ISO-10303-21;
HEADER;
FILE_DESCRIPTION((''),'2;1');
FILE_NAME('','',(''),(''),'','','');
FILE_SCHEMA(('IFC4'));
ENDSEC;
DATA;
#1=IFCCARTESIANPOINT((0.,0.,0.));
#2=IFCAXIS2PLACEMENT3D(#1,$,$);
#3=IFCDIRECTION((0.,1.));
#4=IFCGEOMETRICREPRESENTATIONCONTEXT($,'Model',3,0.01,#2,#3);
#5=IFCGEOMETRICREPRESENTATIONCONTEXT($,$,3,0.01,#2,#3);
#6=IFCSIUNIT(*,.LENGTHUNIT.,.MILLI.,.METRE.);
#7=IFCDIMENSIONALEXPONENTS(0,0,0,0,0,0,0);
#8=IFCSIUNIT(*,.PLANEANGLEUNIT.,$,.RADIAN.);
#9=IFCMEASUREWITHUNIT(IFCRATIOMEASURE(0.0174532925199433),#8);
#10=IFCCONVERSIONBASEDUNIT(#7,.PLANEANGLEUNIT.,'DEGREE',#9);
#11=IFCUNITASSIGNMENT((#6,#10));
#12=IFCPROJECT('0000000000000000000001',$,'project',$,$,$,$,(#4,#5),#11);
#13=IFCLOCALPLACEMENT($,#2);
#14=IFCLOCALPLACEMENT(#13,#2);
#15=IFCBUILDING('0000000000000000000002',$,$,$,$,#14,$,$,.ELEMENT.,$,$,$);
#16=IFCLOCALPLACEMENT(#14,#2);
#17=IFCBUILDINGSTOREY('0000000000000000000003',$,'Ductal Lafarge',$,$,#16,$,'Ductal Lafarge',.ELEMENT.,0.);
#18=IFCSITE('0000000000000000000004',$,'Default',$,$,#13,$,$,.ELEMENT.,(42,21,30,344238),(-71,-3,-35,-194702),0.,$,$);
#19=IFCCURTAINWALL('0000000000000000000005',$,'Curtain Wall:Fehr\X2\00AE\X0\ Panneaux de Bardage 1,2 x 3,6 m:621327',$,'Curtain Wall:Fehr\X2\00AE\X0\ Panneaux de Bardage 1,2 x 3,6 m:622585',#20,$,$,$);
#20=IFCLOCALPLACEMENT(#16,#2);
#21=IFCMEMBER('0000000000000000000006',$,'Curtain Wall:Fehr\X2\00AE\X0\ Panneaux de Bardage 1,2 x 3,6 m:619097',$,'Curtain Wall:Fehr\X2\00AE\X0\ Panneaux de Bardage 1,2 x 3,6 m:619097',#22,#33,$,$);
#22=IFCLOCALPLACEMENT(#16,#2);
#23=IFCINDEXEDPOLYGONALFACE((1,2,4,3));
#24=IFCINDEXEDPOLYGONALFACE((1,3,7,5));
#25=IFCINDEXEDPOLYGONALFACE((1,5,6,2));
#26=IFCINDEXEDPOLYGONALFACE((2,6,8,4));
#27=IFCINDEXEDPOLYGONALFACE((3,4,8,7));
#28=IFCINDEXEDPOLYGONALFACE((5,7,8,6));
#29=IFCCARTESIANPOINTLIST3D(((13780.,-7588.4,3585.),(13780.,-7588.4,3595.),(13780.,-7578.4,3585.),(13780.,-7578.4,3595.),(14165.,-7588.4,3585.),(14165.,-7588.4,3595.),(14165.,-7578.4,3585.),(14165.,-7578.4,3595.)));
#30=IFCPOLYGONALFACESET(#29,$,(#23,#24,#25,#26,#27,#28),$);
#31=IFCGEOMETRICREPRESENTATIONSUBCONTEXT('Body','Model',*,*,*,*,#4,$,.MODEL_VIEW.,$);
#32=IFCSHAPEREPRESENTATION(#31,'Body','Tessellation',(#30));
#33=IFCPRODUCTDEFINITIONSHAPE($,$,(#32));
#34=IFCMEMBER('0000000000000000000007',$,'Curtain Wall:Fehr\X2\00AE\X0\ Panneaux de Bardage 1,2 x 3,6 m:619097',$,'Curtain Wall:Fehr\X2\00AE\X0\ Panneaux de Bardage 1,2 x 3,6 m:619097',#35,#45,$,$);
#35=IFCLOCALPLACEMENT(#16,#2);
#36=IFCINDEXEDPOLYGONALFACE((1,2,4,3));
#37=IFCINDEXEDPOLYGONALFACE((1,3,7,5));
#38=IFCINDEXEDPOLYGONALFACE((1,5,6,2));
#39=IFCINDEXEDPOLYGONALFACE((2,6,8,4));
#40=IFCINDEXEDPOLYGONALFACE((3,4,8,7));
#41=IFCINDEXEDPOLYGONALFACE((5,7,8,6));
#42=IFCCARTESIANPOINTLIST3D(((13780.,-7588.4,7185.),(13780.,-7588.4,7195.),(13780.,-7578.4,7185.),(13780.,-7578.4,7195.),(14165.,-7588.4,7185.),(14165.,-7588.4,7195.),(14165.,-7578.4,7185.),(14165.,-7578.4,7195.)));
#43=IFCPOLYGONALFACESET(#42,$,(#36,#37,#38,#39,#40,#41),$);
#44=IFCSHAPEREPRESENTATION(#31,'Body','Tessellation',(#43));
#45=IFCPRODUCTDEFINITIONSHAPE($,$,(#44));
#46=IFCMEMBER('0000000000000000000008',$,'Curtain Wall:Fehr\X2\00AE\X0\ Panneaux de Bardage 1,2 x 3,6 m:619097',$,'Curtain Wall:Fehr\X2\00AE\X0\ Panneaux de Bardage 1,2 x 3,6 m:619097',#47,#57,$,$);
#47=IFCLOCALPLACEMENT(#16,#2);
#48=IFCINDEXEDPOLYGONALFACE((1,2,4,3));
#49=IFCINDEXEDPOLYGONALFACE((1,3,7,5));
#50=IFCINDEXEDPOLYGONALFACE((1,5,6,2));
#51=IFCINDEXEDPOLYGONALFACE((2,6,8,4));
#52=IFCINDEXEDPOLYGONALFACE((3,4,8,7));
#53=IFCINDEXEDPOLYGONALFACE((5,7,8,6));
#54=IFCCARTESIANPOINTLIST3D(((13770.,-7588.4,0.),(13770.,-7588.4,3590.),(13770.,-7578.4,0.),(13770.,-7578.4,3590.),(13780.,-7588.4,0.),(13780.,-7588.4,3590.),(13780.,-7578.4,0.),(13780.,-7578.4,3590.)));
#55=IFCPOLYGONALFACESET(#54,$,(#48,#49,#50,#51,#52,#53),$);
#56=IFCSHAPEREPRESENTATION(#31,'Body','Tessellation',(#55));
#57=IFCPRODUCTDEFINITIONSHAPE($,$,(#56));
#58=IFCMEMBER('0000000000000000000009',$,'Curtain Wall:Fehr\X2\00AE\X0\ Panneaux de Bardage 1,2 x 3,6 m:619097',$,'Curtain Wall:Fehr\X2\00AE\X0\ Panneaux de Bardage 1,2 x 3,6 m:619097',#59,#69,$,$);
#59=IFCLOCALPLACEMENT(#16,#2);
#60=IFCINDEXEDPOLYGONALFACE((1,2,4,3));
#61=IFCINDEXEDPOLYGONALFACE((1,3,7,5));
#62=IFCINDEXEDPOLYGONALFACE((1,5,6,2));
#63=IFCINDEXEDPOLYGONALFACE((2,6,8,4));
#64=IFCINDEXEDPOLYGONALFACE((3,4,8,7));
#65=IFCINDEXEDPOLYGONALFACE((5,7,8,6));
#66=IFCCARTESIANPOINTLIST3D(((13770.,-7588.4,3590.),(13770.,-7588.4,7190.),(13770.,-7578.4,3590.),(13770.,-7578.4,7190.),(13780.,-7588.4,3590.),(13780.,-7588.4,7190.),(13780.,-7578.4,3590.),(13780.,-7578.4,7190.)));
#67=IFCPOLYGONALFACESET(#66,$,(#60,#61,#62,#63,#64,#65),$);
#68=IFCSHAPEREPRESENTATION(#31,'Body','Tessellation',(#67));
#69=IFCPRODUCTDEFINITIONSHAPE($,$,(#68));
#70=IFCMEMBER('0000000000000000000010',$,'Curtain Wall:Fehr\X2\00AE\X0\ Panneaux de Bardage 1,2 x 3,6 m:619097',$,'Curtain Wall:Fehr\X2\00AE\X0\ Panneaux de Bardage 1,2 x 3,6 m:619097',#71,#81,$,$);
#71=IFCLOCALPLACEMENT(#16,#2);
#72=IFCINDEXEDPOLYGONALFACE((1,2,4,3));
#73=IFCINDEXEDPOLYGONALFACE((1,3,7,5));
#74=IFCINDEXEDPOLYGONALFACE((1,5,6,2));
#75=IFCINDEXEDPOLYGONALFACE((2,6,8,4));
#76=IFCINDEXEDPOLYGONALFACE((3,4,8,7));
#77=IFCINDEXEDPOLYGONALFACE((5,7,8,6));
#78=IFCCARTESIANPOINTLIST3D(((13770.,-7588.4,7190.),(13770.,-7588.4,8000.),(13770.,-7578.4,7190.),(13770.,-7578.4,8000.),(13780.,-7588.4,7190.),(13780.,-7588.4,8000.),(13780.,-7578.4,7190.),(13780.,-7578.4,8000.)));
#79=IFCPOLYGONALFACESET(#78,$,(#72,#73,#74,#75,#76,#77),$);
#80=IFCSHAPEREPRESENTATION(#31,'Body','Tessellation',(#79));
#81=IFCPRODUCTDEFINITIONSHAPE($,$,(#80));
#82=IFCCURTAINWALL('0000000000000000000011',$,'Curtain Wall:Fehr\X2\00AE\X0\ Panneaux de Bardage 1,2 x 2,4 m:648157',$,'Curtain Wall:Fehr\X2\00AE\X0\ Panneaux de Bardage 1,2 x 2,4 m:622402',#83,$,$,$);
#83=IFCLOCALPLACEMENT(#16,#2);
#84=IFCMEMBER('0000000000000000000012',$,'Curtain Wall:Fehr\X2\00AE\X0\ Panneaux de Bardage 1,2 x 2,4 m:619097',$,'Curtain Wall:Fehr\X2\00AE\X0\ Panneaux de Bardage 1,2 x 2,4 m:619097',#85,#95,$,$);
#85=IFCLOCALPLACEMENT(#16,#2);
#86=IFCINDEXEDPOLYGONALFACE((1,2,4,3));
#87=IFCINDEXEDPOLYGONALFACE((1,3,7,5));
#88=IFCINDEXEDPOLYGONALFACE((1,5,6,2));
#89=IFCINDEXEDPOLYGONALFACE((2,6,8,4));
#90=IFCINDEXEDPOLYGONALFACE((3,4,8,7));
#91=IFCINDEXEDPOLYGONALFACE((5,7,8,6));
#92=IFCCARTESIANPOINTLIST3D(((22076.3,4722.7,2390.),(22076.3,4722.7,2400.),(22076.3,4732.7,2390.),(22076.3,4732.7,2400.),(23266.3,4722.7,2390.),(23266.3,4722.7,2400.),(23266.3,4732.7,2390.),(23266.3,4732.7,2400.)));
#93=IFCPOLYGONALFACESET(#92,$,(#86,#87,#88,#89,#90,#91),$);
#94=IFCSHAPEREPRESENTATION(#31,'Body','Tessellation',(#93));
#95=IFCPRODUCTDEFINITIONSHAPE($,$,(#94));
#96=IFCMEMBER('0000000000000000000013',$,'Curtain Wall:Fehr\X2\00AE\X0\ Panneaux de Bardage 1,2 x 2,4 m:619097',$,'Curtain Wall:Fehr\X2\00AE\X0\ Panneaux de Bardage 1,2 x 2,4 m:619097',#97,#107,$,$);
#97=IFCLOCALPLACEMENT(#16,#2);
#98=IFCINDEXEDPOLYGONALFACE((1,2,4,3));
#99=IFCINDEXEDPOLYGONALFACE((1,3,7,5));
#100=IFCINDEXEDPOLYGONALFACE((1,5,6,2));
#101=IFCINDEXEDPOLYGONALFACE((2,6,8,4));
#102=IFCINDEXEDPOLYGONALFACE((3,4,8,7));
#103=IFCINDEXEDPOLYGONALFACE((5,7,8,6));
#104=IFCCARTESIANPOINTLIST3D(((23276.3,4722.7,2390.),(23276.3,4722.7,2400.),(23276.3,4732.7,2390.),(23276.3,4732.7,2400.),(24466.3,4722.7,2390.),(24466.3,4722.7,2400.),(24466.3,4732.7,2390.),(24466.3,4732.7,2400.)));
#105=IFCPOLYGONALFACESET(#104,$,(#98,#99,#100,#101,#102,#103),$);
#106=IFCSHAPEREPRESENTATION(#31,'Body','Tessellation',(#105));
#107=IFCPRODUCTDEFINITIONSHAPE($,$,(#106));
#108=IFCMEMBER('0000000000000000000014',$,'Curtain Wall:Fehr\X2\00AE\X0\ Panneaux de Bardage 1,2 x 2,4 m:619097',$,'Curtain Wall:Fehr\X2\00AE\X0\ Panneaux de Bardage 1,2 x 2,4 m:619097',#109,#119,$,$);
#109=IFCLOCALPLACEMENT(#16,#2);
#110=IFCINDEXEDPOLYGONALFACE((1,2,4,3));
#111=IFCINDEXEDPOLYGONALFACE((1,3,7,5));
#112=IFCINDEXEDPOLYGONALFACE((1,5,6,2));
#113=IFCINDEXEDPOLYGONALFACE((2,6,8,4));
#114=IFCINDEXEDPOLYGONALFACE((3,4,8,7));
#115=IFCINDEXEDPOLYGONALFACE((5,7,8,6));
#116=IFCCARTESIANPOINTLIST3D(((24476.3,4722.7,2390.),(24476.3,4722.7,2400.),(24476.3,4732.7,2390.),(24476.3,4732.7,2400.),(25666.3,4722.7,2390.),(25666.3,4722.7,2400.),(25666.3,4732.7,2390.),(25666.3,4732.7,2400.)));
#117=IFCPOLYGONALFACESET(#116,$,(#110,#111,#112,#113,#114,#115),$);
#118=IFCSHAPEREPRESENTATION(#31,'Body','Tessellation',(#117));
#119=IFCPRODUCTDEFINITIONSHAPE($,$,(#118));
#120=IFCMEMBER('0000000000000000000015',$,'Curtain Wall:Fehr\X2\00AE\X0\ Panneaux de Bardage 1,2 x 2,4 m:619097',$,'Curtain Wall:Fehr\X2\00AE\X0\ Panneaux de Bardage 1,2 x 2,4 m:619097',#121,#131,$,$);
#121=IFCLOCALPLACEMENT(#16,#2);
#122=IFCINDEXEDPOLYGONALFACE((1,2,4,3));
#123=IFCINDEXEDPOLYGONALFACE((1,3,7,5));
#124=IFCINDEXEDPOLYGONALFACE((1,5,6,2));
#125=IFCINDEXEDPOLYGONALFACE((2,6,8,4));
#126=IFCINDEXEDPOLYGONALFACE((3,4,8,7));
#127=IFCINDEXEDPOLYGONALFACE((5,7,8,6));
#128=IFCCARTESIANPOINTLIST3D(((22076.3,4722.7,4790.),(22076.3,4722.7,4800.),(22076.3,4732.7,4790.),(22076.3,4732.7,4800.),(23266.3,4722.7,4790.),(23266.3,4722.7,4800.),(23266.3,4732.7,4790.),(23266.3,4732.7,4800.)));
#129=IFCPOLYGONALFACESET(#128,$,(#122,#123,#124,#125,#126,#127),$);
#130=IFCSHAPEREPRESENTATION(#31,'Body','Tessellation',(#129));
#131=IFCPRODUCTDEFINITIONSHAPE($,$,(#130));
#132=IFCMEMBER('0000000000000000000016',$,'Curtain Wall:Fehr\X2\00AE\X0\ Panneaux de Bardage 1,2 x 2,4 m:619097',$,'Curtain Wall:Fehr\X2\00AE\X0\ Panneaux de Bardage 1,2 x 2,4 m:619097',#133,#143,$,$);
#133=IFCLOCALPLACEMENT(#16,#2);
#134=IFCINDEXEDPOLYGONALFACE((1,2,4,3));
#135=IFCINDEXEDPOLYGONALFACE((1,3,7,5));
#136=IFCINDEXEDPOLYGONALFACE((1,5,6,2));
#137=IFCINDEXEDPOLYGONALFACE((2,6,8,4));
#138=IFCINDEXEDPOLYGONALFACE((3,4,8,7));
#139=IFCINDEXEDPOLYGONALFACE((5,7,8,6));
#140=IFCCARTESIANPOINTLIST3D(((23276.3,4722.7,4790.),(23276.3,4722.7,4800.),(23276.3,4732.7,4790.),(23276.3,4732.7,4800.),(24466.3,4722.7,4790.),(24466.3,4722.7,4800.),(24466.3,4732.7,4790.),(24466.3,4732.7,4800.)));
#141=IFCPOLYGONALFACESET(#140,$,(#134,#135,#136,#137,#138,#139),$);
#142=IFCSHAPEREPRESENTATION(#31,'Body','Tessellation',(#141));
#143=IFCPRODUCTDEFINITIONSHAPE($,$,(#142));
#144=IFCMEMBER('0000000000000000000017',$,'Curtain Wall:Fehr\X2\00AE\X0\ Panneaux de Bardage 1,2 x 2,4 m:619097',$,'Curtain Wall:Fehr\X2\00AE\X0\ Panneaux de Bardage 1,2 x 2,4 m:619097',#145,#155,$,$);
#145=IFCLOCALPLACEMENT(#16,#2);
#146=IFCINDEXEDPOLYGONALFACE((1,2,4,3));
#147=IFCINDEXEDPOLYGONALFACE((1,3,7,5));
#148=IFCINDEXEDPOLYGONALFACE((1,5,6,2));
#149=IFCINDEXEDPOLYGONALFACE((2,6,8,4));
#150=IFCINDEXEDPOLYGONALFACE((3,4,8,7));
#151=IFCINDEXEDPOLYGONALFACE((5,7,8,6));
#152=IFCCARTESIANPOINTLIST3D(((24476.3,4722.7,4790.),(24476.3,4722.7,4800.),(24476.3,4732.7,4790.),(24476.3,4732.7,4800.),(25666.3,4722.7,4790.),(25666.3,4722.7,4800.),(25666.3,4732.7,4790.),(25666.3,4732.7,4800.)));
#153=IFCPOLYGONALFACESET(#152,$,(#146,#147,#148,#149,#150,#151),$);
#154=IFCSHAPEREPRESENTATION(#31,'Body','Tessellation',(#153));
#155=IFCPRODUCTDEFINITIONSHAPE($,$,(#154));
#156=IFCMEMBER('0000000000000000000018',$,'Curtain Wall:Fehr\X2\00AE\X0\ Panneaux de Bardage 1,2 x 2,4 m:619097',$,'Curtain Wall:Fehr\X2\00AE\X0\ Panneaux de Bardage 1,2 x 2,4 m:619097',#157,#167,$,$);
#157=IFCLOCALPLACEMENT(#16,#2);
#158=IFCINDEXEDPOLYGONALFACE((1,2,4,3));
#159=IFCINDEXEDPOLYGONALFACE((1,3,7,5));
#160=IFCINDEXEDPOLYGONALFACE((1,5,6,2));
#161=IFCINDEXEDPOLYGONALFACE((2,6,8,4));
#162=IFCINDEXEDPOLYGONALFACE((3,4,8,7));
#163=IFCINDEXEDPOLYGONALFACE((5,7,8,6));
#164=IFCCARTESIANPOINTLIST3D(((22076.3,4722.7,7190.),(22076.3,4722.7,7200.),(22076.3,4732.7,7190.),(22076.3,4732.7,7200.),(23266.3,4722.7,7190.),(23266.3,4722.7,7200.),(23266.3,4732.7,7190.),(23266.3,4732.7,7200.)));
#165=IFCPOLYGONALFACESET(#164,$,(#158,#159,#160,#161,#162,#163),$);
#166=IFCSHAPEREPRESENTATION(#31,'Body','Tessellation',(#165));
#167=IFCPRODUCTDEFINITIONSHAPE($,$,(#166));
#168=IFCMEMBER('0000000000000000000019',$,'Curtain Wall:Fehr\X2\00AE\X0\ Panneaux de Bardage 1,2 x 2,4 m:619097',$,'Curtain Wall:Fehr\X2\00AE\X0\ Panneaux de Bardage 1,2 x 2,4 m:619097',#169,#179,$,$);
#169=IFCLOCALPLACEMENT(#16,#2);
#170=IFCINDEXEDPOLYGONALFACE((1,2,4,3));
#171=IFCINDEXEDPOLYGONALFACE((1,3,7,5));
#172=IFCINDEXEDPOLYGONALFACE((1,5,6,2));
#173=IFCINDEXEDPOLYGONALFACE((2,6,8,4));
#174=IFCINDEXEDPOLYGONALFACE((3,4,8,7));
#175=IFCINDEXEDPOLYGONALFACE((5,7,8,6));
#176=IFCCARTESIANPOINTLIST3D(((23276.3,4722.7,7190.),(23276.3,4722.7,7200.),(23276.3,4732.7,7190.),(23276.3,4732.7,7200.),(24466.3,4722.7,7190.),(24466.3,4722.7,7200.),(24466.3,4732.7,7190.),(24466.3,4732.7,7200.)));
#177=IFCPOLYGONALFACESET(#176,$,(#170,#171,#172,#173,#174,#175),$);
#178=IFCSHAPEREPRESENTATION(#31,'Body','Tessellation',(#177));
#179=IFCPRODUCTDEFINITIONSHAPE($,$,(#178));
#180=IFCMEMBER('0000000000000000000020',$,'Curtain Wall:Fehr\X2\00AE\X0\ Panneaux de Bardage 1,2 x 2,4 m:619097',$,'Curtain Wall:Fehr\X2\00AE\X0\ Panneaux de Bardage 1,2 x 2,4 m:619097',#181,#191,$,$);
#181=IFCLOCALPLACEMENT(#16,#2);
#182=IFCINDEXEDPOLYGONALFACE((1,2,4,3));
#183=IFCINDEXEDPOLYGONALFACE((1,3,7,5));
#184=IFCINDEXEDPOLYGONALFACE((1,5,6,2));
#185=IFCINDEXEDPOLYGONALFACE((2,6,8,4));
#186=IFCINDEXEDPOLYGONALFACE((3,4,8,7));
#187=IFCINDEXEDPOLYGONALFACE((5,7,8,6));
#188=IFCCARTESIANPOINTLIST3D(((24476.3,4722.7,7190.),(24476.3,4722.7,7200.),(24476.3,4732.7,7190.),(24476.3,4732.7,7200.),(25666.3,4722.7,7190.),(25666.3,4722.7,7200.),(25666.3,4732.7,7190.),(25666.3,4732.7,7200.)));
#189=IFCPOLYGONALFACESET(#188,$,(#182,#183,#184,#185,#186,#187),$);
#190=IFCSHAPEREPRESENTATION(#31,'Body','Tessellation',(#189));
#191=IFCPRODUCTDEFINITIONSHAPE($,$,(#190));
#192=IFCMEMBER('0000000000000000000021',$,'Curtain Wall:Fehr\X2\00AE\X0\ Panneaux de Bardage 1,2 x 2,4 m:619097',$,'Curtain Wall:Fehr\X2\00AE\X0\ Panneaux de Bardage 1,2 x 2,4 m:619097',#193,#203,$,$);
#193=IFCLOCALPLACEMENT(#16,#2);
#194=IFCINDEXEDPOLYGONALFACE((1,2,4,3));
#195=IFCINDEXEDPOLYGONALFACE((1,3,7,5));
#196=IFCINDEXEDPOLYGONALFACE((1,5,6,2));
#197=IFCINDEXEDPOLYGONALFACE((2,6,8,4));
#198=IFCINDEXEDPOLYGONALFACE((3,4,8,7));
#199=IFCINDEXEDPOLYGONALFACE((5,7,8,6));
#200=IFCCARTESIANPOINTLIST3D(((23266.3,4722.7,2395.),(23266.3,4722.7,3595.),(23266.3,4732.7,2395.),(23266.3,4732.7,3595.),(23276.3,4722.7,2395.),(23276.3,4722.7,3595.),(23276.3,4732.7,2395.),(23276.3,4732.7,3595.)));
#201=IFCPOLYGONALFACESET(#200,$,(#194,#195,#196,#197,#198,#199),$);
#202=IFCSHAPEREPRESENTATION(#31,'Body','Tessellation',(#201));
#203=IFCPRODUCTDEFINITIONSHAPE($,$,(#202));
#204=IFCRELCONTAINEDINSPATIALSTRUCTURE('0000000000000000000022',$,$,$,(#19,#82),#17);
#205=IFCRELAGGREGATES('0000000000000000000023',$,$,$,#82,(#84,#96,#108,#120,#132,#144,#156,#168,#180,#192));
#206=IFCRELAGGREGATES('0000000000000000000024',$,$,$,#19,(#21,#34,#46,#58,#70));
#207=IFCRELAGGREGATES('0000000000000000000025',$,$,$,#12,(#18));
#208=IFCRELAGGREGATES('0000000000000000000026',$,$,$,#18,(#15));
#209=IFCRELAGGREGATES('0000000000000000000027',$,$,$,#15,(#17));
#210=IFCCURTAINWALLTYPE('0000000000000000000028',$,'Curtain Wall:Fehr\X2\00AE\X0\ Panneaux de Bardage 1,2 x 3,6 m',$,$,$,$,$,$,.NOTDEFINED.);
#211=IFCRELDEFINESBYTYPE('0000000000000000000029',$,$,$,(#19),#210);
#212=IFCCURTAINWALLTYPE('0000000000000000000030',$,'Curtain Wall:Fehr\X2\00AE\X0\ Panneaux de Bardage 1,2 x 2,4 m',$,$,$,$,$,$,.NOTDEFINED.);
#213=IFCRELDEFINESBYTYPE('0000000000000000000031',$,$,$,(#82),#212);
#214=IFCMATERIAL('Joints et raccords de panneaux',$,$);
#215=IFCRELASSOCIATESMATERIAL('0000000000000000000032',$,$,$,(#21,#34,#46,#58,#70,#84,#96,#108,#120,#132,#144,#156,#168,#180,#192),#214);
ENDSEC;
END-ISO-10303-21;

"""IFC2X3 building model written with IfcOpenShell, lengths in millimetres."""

from ifc_helpers import new_model, entity, si_unit, converted_unit, direction, frame, frame_2d, origin, place, context, subcontext, project, spatial, rectangle, extrude, material, type_object, element, aggregate, save


model = new_model("IFC2X3")

# Units and contexts
model_context = context("Model", 3, precision=0.01, world=origin(), true_north=direction((0.0, 1.0)))
context_of_model = context(None, 3, precision=0.01, world=origin(), true_north=direction((0.0, 1.0)))
body_context = subcontext(model_context, "Body", "Model", "MODEL_VIEW")
ifc_project = project(units=[si_unit("LENGTHUNIT", "METRE", prefix="MILLI"), converted_unit("PLANEANGLEUNIT", "DEGREE", entity("IfcRatioMeasure", 0.0174532925199433), si_unit("PLANEANGLEUNIT", "RADIAN"), dimensions=[0, 0, 0, 0, 0, 0, 0])], contexts=[model_context, context_of_model])

# Site, building, storey
site_placement = place(None, origin())
site = spatial("IfcSite", under=ifc_project, at=site_placement, Name="Default", CompositionType="ELEMENT", RefLatitude=(42, 21, 30, 344238), RefLongitude=(-71, -3, -35, -194702), RefElevation=0.0)
building_placement = place(site_placement, origin())
building = spatial("IfcBuilding", under=site, at=building_placement, CompositionType="ELEMENT")
storey_placement = place(building_placement, origin())
storey = spatial("IfcBuildingStorey", under=building, at=storey_placement, Name="Ductal Lafarge", LongName="Ductal Lafarge", CompositionType="ELEMENT", Elevation=0.0)

# Curtain walls, members
curtain_wall_type_1 = type_object("IfcCurtainWallType", Name="Curtain Wall:Fehr® Panneaux de Bardage 1,2 x 3,6 m", PredefinedType="NOTDEFINED")
curtain_wall_1_placement = place(storey_placement, origin())
curtain_wall_1 = element("IfcCurtainWall", 1, at=curtain_wall_1_placement, inside=storey, type_object=curtain_wall_type_1, Name="Curtain Wall:Fehr® Panneaux de Bardage 1,2 x 3,6 m:621327", ObjectType="Curtain Wall:Fehr® Panneaux de Bardage 1,2 x 3,6 m:622585")
ifc_material_1 = material(Name="Joints et raccords de panneaux")
member_1_placement = place(curtain_wall_1_placement, frame((13780.0, -7588.4, 3585.0)))
member_1 = element("IfcMember", 2, at=member_1_placement, material=ifc_material_1, Name="Curtain Wall:Fehr® Panneaux de Bardage 1,2 x 3,6 m:619097", ObjectType="Curtain Wall:Fehr® Panneaux de Bardage 1,2 x 3,6 m:619097", context=body_context, shape_type="SweptSolid", body=[
    extrude(rectangle(XDim=385.0, YDim=10.0, at=frame_2d((0.0, 0.0), x_axis=(1.0, 0.0))), frame((192.5, 5.0, 0.0), z_axis=(0.0, 0.0, 1.0), x_axis=(-1.0, 0.0, 0.0)), (0.0, 0.0, 1.0), 10.0),
])
member_2_placement = place(curtain_wall_1_placement, frame((13780.0, -7588.4, 7185.0)))
member_2 = element("IfcMember", 3, at=member_2_placement, material=ifc_material_1, Name="Curtain Wall:Fehr® Panneaux de Bardage 1,2 x 3,6 m:619097", ObjectType="Curtain Wall:Fehr® Panneaux de Bardage 1,2 x 3,6 m:619097", context=body_context, shape_type="SweptSolid", body=[
    extrude(rectangle(XDim=385.0, YDim=10.0, at=frame_2d((0.0, 0.0), x_axis=(1.0, 0.0))), frame((192.5, 5.0, 0.0), z_axis=(0.0, 0.0, 1.0), x_axis=(-1.0, 0.0, 0.0)), (0.0, 0.0, 1.0), 10.0),
])
member_3_placement = place(curtain_wall_1_placement, frame((13770.0, -7588.4, 0.0)))
member_3 = element("IfcMember", 4, at=member_3_placement, material=ifc_material_1, Name="Curtain Wall:Fehr® Panneaux de Bardage 1,2 x 3,6 m:619097", ObjectType="Curtain Wall:Fehr® Panneaux de Bardage 1,2 x 3,6 m:619097", context=body_context, shape_type="SweptSolid", body=[
    extrude(rectangle(XDim=10.0, YDim=10.0, at=frame_2d((0.0, 0.0), x_axis=(1.0, 0.0))), frame((5.0, 5.0, 0.0), z_axis=(0.0, 0.0, 1.0), x_axis=(0.0, 1.0, 0.0)), (0.0, 0.0, 1.0), 3590.0),
])
member_4_placement = place(curtain_wall_1_placement, frame((13770.0, -7588.4, 3590.0)))
member_4 = element("IfcMember", 5, at=member_4_placement, material=ifc_material_1, Name="Curtain Wall:Fehr® Panneaux de Bardage 1,2 x 3,6 m:619097", ObjectType="Curtain Wall:Fehr® Panneaux de Bardage 1,2 x 3,6 m:619097", context=body_context, shape_type="SweptSolid", body=[
    extrude(rectangle(XDim=10.0, YDim=10.0, at=frame_2d((0.0, 0.0), x_axis=(1.0, 0.0))), frame((5.0, 5.0, 0.0), z_axis=(0.0, 0.0, 1.0), x_axis=(0.0, 1.0, 0.0)), (0.0, 0.0, 1.0), 3600.0),
])
member_5_placement = place(curtain_wall_1_placement, frame((13770.0, -7588.4, 7190.0)))
member_5 = element("IfcMember", 6, at=member_5_placement, material=ifc_material_1, Name="Curtain Wall:Fehr® Panneaux de Bardage 1,2 x 3,6 m:619097", ObjectType="Curtain Wall:Fehr® Panneaux de Bardage 1,2 x 3,6 m:619097", context=body_context, shape_type="SweptSolid", body=[
    extrude(rectangle(XDim=10.0, YDim=10.0, at=frame_2d((0.0, 0.0), x_axis=(1.0, 0.0))), frame((5.0, 5.0, 0.0), z_axis=(0.0, 0.0, 1.0), x_axis=(0.0, 1.0, 0.0)), (0.0, 0.0, 1.0), 810.0),
])
curtain_wall_type_2 = type_object("IfcCurtainWallType", Name="Curtain Wall:Fehr® Panneaux de Bardage 1,2 x 2,4 m", PredefinedType="NOTDEFINED")
curtain_wall_2_placement = place(storey_placement, origin())
curtain_wall_2 = element("IfcCurtainWall", 7, at=curtain_wall_2_placement, inside=storey, type_object=curtain_wall_type_2, Name="Curtain Wall:Fehr® Panneaux de Bardage 1,2 x 2,4 m:648157", ObjectType="Curtain Wall:Fehr® Panneaux de Bardage 1,2 x 2,4 m:622402")
member_6_placement = place(curtain_wall_2_placement, frame((22076.3, 4722.7, 2390.0)))
member_6 = element("IfcMember", 8, at=member_6_placement, material=ifc_material_1, Name="Curtain Wall:Fehr® Panneaux de Bardage 1,2 x 2,4 m:619097", ObjectType="Curtain Wall:Fehr® Panneaux de Bardage 1,2 x 2,4 m:619097", context=body_context, shape_type="SweptSolid", body=[
    extrude(rectangle(XDim=1190.0, YDim=10.0, at=frame_2d((0.0, 0.0), x_axis=(1.0, 0.0))), frame((595.0, 5.0, 0.0), z_axis=(0.0, 0.0, 1.0), x_axis=(-1.0, 0.0, 0.0)), (0.0, 0.0, 1.0), 10.0),
])
member_7_placement = place(curtain_wall_2_placement, frame((23276.3, 4722.7, 2390.0)))
member_7 = element("IfcMember", 9, at=member_7_placement, material=ifc_material_1, Name="Curtain Wall:Fehr® Panneaux de Bardage 1,2 x 2,4 m:619097", ObjectType="Curtain Wall:Fehr® Panneaux de Bardage 1,2 x 2,4 m:619097", context=body_context, shape_type="SweptSolid", body=[
    extrude(rectangle(XDim=1190.0, YDim=10.0, at=frame_2d((0.0, 0.0), x_axis=(1.0, 0.0))), frame((595.0, 5.0, 0.0), z_axis=(0.0, 0.0, 1.0), x_axis=(-1.0, 0.0, 0.0)), (0.0, 0.0, 1.0), 10.0),
])
member_8_placement = place(curtain_wall_2_placement, frame((24476.3, 4722.7, 2390.0)))
member_8 = element("IfcMember", 10, at=member_8_placement, material=ifc_material_1, Name="Curtain Wall:Fehr® Panneaux de Bardage 1,2 x 2,4 m:619097", ObjectType="Curtain Wall:Fehr® Panneaux de Bardage 1,2 x 2,4 m:619097", context=body_context, shape_type="SweptSolid", body=[
    extrude(rectangle(XDim=1190.0, YDim=10.0, at=frame_2d((0.0, 0.0), x_axis=(1.0, 0.0))), frame((595.0, 5.0, 0.0), z_axis=(0.0, 0.0, 1.0), x_axis=(-1.0, 0.0, 0.0)), (0.0, 0.0, 1.0), 10.0),
])
member_9_placement = place(curtain_wall_2_placement, frame((22076.3, 4722.7, 4790.0)))
member_9 = element("IfcMember", 11, at=member_9_placement, material=ifc_material_1, Name="Curtain Wall:Fehr® Panneaux de Bardage 1,2 x 2,4 m:619097", ObjectType="Curtain Wall:Fehr® Panneaux de Bardage 1,2 x 2,4 m:619097", context=body_context, shape_type="SweptSolid", body=[
    extrude(rectangle(XDim=1190.0, YDim=10.0, at=frame_2d((0.0, 0.0), x_axis=(1.0, 0.0))), frame((595.0, 5.0, 0.0), z_axis=(0.0, 0.0, 1.0), x_axis=(-1.0, 0.0, 0.0)), (0.0, 0.0, 1.0), 10.0),
])
member_10_placement = place(curtain_wall_2_placement, frame((23276.3, 4722.7, 4790.0)))
member_10 = element("IfcMember", 12, at=member_10_placement, material=ifc_material_1, Name="Curtain Wall:Fehr® Panneaux de Bardage 1,2 x 2,4 m:619097", ObjectType="Curtain Wall:Fehr® Panneaux de Bardage 1,2 x 2,4 m:619097", context=body_context, shape_type="SweptSolid", body=[
    extrude(rectangle(XDim=1190.0, YDim=10.0, at=frame_2d((0.0, 0.0), x_axis=(1.0, 0.0))), frame((595.0, 5.0, 0.0), z_axis=(0.0, 0.0, 1.0), x_axis=(-1.0, 0.0, 0.0)), (0.0, 0.0, 1.0), 10.0),
])
member_11_placement = place(curtain_wall_2_placement, frame((24476.3, 4722.7, 4790.0)))
member_11 = element("IfcMember", 13, at=member_11_placement, material=ifc_material_1, Name="Curtain Wall:Fehr® Panneaux de Bardage 1,2 x 2,4 m:619097", ObjectType="Curtain Wall:Fehr® Panneaux de Bardage 1,2 x 2,4 m:619097", context=body_context, shape_type="SweptSolid", body=[
    extrude(rectangle(XDim=1190.0, YDim=10.0, at=frame_2d((0.0, 0.0), x_axis=(1.0, 0.0))), frame((595.0, 5.0, 0.0), z_axis=(0.0, 0.0, 1.0), x_axis=(-1.0, 0.0, 0.0)), (0.0, 0.0, 1.0), 10.0),
])
member_12_placement = place(curtain_wall_2_placement, frame((22076.3, 4722.7, 7190.0)))
member_12 = element("IfcMember", 14, at=member_12_placement, material=ifc_material_1, Name="Curtain Wall:Fehr® Panneaux de Bardage 1,2 x 2,4 m:619097", ObjectType="Curtain Wall:Fehr® Panneaux de Bardage 1,2 x 2,4 m:619097", context=body_context, shape_type="SweptSolid", body=[
    extrude(rectangle(XDim=1190.0, YDim=10.0, at=frame_2d((0.0, 0.0), x_axis=(1.0, 0.0))), frame((595.0, 5.0, 0.0), z_axis=(0.0, 0.0, 1.0), x_axis=(-1.0, 0.0, 0.0)), (0.0, 0.0, 1.0), 10.0),
])
member_13_placement = place(curtain_wall_2_placement, frame((23276.3, 4722.7, 7190.0)))
member_13 = element("IfcMember", 15, at=member_13_placement, material=ifc_material_1, Name="Curtain Wall:Fehr® Panneaux de Bardage 1,2 x 2,4 m:619097", ObjectType="Curtain Wall:Fehr® Panneaux de Bardage 1,2 x 2,4 m:619097", context=body_context, shape_type="SweptSolid", body=[
    extrude(rectangle(XDim=1190.0, YDim=10.0, at=frame_2d((0.0, 0.0), x_axis=(1.0, 0.0))), frame((595.0, 5.0, 0.0), z_axis=(0.0, 0.0, 1.0), x_axis=(-1.0, 0.0, 0.0)), (0.0, 0.0, 1.0), 10.0),
])
member_14_placement = place(curtain_wall_2_placement, frame((24476.3, 4722.7, 7190.0)))
member_14 = element("IfcMember", 16, at=member_14_placement, material=ifc_material_1, Name="Curtain Wall:Fehr® Panneaux de Bardage 1,2 x 2,4 m:619097", ObjectType="Curtain Wall:Fehr® Panneaux de Bardage 1,2 x 2,4 m:619097", context=body_context, shape_type="SweptSolid", body=[
    extrude(rectangle(XDim=1190.0, YDim=10.0, at=frame_2d((0.0, 0.0), x_axis=(1.0, 0.0))), frame((595.0, 5.0, 0.0), z_axis=(0.0, 0.0, 1.0), x_axis=(-1.0, 0.0, 0.0)), (0.0, 0.0, 1.0), 10.0),
])
member_15_placement = place(curtain_wall_2_placement, frame((23266.3, 4722.7, 2395.0)))
member_15 = element("IfcMember", 17, at=member_15_placement, material=ifc_material_1, Name="Curtain Wall:Fehr® Panneaux de Bardage 1,2 x 2,4 m:619097", ObjectType="Curtain Wall:Fehr® Panneaux de Bardage 1,2 x 2,4 m:619097", context=body_context, shape_type="SweptSolid", body=[
    extrude(rectangle(XDim=10.0, YDim=10.0, at=frame_2d((0.0, 0.0), x_axis=(1.0, 0.0))), frame((5.0, 5.0, 0.0), z_axis=(0.0, 0.0, 1.0), x_axis=(0.0, 1.0, 0.0)), (0.0, 0.0, 1.0), 1200.0),
])
aggregate(curtain_wall_2, [member_6, member_7, member_8, member_9, member_10, member_11, member_12, member_13, member_14, member_15])

aggregate(curtain_wall_1, [member_1, member_2, member_3, member_4, member_5])

save(model, "model.ifc")
